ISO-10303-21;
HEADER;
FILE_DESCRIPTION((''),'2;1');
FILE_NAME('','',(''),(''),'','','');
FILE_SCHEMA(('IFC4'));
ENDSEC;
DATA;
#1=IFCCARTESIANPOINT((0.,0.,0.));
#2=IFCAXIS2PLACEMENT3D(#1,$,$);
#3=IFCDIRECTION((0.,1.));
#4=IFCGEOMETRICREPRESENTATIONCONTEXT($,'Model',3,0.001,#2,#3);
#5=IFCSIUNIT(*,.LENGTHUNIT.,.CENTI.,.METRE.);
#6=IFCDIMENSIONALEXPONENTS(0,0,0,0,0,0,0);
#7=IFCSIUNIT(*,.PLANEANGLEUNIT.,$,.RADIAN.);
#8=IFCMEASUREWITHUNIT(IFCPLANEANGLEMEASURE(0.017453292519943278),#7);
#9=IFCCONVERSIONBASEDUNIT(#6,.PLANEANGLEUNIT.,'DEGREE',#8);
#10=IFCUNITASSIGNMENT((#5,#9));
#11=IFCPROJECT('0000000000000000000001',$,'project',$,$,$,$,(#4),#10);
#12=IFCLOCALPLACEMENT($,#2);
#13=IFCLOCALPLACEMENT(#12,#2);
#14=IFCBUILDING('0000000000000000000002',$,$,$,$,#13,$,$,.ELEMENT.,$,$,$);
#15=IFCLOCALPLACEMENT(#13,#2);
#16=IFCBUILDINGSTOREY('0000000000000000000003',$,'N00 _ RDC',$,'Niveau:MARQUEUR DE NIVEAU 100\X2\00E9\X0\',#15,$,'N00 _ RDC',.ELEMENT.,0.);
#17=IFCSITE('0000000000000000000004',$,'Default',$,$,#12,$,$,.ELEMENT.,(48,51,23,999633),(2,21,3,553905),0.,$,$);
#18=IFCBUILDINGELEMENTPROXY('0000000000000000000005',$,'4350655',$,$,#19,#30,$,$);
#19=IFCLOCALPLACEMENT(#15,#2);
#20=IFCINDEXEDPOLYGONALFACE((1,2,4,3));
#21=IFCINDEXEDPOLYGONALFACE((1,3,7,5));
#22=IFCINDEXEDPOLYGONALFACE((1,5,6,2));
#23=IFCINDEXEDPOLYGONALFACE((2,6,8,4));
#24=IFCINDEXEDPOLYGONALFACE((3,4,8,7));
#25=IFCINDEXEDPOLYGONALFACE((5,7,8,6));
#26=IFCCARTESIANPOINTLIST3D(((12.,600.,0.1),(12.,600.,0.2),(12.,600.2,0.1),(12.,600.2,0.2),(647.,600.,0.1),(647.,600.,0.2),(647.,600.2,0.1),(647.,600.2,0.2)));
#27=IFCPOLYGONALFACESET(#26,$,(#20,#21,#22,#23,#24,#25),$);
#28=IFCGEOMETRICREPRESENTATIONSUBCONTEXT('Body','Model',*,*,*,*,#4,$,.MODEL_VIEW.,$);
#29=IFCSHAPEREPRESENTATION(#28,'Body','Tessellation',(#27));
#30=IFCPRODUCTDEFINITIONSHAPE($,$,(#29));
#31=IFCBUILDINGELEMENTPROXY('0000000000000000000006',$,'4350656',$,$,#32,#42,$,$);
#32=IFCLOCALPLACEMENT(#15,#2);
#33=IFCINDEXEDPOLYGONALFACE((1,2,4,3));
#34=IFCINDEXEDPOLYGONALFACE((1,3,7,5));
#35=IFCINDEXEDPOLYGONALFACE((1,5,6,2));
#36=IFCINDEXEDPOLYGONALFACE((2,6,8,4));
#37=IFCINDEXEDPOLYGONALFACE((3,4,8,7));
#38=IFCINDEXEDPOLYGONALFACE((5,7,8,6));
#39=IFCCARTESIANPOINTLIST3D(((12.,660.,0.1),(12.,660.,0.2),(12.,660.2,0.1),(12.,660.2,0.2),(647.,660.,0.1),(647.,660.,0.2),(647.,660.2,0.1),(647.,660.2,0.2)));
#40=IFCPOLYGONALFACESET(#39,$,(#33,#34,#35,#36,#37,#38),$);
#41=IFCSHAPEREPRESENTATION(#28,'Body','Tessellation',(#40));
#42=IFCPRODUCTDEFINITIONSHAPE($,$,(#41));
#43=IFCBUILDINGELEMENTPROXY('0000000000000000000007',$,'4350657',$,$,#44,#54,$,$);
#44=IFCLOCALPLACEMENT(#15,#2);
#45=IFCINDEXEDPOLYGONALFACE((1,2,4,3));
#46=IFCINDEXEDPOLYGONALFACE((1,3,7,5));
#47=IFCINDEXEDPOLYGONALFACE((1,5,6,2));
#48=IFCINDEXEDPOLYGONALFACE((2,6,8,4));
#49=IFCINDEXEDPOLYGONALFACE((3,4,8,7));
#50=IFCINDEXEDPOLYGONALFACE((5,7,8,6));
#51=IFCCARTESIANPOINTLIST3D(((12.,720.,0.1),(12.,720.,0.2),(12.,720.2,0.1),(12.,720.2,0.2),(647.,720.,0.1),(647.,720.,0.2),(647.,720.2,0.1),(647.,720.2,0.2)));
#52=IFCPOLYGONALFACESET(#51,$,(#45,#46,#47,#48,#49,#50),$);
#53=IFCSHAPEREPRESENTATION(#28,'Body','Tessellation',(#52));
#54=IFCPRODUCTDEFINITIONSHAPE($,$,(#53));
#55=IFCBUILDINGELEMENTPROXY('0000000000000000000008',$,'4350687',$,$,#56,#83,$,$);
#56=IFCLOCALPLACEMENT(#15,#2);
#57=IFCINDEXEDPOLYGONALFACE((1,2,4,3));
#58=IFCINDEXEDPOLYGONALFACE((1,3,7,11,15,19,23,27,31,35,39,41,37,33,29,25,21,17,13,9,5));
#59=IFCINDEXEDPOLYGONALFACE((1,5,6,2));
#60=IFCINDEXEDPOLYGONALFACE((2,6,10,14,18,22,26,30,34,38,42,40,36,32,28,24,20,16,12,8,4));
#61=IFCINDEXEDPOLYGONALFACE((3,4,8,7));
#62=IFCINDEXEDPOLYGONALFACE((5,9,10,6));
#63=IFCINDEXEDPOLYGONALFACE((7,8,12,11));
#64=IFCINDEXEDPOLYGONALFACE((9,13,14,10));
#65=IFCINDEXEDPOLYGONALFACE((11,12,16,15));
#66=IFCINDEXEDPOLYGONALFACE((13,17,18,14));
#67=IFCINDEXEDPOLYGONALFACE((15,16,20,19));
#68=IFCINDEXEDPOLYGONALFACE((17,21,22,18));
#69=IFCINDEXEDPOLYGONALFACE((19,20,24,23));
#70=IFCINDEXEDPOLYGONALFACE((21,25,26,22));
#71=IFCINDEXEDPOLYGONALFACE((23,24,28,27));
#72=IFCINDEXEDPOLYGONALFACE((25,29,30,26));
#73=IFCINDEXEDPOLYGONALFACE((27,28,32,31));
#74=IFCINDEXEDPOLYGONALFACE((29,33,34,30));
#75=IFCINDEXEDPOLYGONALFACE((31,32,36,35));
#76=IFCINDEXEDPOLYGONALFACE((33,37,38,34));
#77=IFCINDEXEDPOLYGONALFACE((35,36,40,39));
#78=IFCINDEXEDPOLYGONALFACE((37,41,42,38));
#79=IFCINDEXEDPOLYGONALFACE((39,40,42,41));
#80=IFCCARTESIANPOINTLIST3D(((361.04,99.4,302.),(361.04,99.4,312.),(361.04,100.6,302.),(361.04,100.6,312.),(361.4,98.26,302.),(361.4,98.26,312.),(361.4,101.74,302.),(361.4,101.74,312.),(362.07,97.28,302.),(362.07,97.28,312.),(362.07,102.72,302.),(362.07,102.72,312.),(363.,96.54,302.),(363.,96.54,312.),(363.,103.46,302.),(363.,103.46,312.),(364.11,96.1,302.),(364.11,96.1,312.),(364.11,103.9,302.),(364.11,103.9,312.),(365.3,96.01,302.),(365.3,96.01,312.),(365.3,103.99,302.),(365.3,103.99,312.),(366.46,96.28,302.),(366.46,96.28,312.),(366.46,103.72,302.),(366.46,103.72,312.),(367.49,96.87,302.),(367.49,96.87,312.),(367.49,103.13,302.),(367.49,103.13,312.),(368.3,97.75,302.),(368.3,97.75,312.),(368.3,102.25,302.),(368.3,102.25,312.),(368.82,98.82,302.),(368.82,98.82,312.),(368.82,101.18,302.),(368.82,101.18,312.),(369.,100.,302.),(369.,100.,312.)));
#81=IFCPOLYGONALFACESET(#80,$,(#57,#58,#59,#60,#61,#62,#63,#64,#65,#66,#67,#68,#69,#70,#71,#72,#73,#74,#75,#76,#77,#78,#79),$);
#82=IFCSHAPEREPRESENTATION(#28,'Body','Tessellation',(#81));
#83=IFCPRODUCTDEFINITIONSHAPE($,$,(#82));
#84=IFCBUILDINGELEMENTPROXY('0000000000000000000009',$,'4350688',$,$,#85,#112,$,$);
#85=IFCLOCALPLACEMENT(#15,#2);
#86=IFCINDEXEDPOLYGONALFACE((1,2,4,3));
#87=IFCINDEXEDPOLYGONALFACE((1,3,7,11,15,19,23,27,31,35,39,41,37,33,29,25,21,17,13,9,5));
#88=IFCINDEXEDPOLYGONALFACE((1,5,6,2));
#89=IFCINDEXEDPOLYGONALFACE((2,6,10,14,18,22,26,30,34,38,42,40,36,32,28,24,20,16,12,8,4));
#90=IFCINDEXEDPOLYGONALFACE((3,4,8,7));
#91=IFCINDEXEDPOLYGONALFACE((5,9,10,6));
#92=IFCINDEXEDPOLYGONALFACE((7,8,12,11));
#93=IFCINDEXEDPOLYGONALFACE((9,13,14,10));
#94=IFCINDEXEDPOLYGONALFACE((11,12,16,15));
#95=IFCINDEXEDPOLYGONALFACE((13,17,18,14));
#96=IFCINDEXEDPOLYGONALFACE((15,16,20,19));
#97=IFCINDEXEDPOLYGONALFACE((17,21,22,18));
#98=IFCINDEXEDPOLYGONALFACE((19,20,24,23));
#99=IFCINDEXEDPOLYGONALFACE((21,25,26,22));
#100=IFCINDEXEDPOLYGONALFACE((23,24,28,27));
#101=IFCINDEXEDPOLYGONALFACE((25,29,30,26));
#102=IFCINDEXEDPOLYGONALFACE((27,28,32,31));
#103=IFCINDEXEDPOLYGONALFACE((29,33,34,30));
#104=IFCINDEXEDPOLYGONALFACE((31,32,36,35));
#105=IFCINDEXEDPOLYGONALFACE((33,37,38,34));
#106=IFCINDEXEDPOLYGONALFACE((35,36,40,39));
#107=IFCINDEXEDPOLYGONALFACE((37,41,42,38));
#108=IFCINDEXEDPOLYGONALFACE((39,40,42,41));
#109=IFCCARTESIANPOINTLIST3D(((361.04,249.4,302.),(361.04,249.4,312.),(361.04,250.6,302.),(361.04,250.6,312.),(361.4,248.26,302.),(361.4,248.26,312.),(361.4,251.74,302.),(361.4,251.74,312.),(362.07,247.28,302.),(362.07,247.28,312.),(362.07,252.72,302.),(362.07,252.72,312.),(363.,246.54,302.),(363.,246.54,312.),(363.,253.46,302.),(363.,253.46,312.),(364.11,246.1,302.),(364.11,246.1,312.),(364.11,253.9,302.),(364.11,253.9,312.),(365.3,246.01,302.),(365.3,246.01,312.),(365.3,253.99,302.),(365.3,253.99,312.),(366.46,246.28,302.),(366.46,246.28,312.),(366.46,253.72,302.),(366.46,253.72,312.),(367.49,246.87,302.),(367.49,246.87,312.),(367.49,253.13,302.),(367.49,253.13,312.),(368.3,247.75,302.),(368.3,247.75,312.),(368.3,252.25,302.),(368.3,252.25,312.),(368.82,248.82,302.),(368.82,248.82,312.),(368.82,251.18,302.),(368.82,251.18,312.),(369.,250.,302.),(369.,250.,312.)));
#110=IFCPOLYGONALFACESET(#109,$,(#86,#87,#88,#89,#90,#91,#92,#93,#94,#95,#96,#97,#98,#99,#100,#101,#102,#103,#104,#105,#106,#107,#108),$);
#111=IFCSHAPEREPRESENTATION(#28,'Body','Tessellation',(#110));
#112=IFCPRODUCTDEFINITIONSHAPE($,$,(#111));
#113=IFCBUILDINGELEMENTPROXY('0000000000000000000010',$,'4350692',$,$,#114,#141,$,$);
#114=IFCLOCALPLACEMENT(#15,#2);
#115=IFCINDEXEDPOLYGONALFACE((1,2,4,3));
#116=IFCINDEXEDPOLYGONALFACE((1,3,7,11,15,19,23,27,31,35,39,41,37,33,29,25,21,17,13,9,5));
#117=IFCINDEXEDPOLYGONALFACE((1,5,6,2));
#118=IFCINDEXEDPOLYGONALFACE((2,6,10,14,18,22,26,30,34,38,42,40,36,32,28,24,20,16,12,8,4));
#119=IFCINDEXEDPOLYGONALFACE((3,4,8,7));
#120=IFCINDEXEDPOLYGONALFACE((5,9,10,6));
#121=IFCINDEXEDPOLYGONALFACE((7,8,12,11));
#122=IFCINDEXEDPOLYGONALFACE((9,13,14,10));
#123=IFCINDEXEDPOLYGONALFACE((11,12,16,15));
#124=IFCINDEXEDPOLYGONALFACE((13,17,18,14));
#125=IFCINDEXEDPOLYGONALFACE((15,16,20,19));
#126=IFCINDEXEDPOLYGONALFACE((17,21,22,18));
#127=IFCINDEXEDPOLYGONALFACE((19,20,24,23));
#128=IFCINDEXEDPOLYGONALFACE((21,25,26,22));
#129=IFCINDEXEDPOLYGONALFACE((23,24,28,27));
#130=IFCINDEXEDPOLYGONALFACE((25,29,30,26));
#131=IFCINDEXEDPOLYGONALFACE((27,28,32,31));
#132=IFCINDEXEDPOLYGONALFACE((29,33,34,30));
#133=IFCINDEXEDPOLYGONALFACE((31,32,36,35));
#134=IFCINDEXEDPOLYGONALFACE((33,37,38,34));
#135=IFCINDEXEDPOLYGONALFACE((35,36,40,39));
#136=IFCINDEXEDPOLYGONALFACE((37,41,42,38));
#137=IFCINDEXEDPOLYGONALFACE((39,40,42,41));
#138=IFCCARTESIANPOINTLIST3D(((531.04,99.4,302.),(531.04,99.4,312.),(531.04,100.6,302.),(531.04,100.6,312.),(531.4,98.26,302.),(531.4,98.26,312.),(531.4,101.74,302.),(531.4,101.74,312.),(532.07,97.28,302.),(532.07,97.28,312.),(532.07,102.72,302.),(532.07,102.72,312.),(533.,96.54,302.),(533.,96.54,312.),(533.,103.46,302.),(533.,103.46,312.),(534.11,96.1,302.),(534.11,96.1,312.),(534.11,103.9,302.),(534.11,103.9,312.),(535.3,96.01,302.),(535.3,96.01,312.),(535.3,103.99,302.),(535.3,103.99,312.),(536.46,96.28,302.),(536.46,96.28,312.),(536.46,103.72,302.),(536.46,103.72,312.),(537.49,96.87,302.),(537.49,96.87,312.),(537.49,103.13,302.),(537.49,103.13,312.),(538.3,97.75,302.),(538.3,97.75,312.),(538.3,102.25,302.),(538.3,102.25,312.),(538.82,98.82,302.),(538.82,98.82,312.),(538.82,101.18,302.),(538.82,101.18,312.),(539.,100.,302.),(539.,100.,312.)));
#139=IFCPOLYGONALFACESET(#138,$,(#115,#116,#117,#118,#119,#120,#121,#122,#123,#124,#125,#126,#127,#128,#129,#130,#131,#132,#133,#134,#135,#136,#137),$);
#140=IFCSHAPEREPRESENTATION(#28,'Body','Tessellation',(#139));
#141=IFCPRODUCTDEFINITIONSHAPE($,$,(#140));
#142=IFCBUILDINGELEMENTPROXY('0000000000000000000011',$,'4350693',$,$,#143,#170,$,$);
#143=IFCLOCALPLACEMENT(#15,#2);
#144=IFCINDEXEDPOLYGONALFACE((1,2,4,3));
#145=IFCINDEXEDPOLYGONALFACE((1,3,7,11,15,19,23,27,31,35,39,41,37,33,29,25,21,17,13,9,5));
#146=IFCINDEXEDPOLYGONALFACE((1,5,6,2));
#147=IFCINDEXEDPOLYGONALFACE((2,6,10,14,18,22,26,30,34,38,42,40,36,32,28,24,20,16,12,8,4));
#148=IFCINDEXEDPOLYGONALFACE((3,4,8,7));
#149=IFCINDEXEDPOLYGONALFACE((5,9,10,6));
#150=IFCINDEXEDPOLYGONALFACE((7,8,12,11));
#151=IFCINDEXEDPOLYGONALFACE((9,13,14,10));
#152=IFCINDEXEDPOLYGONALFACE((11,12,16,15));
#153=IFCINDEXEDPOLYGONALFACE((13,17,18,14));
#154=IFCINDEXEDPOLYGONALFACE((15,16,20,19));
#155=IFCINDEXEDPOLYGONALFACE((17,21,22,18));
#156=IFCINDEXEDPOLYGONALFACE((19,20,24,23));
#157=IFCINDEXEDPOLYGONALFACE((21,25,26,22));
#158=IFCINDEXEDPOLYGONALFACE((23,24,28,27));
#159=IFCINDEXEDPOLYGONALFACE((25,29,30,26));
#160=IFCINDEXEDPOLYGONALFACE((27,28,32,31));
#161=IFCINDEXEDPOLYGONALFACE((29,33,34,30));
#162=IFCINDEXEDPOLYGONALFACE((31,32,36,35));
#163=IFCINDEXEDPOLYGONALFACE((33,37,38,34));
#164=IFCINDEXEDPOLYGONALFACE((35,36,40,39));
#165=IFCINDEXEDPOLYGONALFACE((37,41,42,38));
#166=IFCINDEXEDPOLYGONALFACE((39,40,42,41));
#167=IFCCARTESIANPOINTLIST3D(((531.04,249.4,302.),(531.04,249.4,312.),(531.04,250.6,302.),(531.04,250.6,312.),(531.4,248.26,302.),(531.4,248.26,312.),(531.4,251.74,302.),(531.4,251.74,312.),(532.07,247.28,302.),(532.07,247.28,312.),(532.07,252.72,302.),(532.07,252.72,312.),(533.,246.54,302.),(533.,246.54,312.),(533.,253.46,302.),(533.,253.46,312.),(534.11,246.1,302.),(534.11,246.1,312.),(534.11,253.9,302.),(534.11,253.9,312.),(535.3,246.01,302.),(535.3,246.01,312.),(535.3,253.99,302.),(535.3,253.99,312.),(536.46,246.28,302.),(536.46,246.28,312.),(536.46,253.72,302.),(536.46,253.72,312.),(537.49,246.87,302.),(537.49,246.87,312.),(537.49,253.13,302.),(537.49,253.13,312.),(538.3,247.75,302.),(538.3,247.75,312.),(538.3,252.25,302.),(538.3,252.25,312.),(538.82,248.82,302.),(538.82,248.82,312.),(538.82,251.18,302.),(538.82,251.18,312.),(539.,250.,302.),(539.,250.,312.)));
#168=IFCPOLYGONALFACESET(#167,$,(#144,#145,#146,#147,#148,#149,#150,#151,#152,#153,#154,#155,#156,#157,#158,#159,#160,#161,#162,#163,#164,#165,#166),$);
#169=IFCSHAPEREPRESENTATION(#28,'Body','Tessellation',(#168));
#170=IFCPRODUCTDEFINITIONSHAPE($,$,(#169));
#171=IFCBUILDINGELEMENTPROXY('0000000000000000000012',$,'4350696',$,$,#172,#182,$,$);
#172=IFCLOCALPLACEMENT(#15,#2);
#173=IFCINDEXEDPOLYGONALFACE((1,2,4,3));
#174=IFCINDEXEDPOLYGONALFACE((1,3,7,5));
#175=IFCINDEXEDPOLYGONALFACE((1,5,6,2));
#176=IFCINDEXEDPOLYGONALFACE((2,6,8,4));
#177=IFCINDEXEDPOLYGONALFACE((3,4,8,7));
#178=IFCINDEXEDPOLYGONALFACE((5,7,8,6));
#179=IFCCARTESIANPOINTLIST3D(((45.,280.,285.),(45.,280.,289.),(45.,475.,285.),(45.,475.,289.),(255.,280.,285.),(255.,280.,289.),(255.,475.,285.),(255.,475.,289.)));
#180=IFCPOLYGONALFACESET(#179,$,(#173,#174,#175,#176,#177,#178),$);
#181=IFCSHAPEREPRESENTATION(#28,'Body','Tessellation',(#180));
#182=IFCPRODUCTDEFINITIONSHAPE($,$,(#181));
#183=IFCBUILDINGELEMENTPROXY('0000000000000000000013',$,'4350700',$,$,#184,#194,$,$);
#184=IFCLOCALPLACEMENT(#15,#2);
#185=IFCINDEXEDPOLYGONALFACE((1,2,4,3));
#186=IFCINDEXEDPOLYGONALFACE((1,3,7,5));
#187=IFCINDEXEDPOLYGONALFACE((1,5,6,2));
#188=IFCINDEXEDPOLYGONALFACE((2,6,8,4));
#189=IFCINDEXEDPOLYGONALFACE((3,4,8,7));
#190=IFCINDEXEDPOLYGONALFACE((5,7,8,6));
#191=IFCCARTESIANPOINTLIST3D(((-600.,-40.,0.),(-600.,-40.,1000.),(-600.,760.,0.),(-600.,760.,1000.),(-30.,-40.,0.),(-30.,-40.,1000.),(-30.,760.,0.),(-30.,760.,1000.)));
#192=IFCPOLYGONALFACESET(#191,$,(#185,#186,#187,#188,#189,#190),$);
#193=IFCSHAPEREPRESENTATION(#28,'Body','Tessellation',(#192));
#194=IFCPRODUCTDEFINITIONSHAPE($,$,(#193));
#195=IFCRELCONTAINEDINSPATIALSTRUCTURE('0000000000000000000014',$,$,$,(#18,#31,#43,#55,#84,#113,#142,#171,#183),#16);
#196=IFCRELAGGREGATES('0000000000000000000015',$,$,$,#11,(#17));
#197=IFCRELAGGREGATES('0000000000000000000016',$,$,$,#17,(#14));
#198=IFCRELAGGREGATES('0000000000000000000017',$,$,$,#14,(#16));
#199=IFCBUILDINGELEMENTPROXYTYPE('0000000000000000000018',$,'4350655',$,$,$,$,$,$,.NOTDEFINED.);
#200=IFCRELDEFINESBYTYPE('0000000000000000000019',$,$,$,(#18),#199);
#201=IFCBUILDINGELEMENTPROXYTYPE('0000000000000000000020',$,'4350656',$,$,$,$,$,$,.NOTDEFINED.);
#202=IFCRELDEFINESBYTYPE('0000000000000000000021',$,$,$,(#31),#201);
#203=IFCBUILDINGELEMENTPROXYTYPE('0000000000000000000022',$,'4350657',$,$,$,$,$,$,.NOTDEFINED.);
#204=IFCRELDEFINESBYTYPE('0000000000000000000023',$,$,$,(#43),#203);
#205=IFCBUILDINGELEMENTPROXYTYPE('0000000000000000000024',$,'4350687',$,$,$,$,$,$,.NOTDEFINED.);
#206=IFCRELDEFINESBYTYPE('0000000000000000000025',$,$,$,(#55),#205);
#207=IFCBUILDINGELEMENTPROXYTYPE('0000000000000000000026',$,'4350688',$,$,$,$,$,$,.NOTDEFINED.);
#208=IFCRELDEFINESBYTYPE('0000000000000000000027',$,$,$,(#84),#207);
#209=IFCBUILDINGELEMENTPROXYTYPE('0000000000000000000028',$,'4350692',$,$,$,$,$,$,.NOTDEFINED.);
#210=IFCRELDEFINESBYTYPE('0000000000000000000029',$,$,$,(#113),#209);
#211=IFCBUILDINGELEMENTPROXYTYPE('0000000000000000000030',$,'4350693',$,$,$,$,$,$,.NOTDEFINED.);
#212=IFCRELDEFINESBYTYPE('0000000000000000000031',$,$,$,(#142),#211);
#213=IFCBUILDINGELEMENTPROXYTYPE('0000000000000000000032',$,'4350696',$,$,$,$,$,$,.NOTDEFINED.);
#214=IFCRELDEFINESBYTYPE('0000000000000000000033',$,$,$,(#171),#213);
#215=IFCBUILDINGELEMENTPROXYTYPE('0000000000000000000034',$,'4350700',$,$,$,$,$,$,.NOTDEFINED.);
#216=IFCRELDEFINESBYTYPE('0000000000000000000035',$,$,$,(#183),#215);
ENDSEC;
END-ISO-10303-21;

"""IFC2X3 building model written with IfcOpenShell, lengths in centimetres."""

from ifc_helpers import new_model, entity, si_unit, converted_unit, direction, frame, frame_2d, origin, origin_2d_with_axis, place, context, subcontext, project, spatial, rectangle, circle, extrude, type_object, element, save


model = new_model("IFC2X3")

# Units and contexts
model_context = context("Model", 3, precision=0.001, world=origin(), true_north=direction((0.0, 1.0)))
body_context = subcontext(model_context, "Body", "Model", "MODEL_VIEW")
ifc_project = project(units=[si_unit("LENGTHUNIT", "METRE", prefix="CENTI"), converted_unit("PLANEANGLEUNIT", "DEGREE", entity("IfcPlaneAngleMeasure", 0.017453292519943278), si_unit("PLANEANGLEUNIT", "RADIAN"), dimensions=[0, 0, 0, 0, 0, 0, 0])], contexts=[model_context])

# Site, building, storey
site_placement = place(None, origin())
site = spatial("IfcSite", under=ifc_project, at=site_placement, Name="Default", CompositionType="ELEMENT", RefLatitude=(48, 51, 23, 999633), RefLongitude=(2, 21, 3, 553905), RefElevation=0.0)
building_placement = place(site_placement, origin())
building = spatial("IfcBuilding", under=site, at=building_placement, CompositionType="ELEMENT")
storey_placement = place(building_placement, origin())
storey = spatial("IfcBuildingStorey", under=building, at=storey_placement, Name="N00 _ RDC", ObjectType="Niveau:MARQUEUR DE NIVEAU 100é", LongName="N00 _ RDC", CompositionType="ELEMENT", Elevation=0.0)

# Building element proxies
building_element_proxy_type_1 = type_object("IfcBuildingElementProxyType", Name="4350655", PredefinedType="NOTDEFINED")
proxy_1_placement = place(storey_placement, origin())
element("IfcBuildingElementProxy", 1, at=proxy_1_placement, inside=storey, type_object=building_element_proxy_type_1, Name="4350655", context=body_context, shape_type="SweptSolid", body=[
    extrude(rectangle(XDim=635.0, YDim=0.2, at=frame_2d((0.0, 0.0), x_axis=(1.0, 0.0))), frame((329.5, 600.1, 0.1)), (0.0, 0.0, 1.0), 0.1),
])
building_element_proxy_type_2 = type_object("IfcBuildingElementProxyType", Name="4350656", PredefinedType="NOTDEFINED")
proxy_2_placement = place(storey_placement, origin())
element("IfcBuildingElementProxy", 2, at=proxy_2_placement, inside=storey, type_object=building_element_proxy_type_2, Name="4350656", context=body_context, shape_type="SweptSolid", body=[
    extrude(rectangle(XDim=635.0, YDim=0.2, at=frame_2d((0.0, 0.0), x_axis=(1.0, 0.0))), frame((329.5, 660.1, 0.1)), (0.0, 0.0, 1.0), 0.1),
])
building_element_proxy_type_3 = type_object("IfcBuildingElementProxyType", Name="4350657", PredefinedType="NOTDEFINED")
proxy_3_placement = place(storey_placement, origin())
element("IfcBuildingElementProxy", 3, at=proxy_3_placement, inside=storey, type_object=building_element_proxy_type_3, Name="4350657", context=body_context, shape_type="SweptSolid", body=[
    extrude(rectangle(XDim=635.0, YDim=0.2, at=frame_2d((0.0, 0.0), x_axis=(1.0, 0.0))), frame((329.5, 720.1, 0.1)), (0.0, 0.0, 1.0), 0.1),
])
building_element_proxy_type_4 = type_object("IfcBuildingElementProxyType", Name="4350687", PredefinedType="NOTDEFINED")
proxy_4_placement = place(storey_placement, origin())
element("IfcBuildingElementProxy", 4, at=proxy_4_placement, inside=storey, type_object=building_element_proxy_type_4, Name="4350687", context=body_context, shape_type="SweptSolid", body=[
    extrude(circle(Radius=4.0, at=origin_2d_with_axis()), frame((365.0, 100.0, 302.0)), (0.0, 0.0, 1.0), 10.0),
])
building_element_proxy_type_5 = type_object("IfcBuildingElementProxyType", Name="4350688", PredefinedType="NOTDEFINED")
proxy_5_placement = place(storey_placement, origin())
element("IfcBuildingElementProxy", 5, at=proxy_5_placement, inside=storey, type_object=building_element_proxy_type_5, Name="4350688", context=body_context, shape_type="SweptSolid", body=[
    extrude(circle(Radius=4.0, at=origin_2d_with_axis()), frame((365.0, 250.0, 302.0)), (0.0, 0.0, 1.0), 10.0),
])
building_element_proxy_type_6 = type_object("IfcBuildingElementProxyType", Name="4350692", PredefinedType="NOTDEFINED")
proxy_6_placement = place(storey_placement, origin())
element("IfcBuildingElementProxy", 6, at=proxy_6_placement, inside=storey, type_object=building_element_proxy_type_6, Name="4350692", context=body_context, shape_type="SweptSolid", body=[
    extrude(circle(Radius=4.0, at=origin_2d_with_axis()), frame((535.0, 100.0, 302.0)), (0.0, 0.0, 1.0), 10.0),
])
building_element_proxy_type_7 = type_object("IfcBuildingElementProxyType", Name="4350693", PredefinedType="NOTDEFINED")
proxy_7_placement = place(storey_placement, origin())
element("IfcBuildingElementProxy", 7, at=proxy_7_placement, inside=storey, type_object=building_element_proxy_type_7, Name="4350693", context=body_context, shape_type="SweptSolid", body=[
    extrude(circle(Radius=4.0, at=origin_2d_with_axis()), frame((535.0, 250.0, 302.0)), (0.0, 0.0, 1.0), 10.0),
])
building_element_proxy_type_8 = type_object("IfcBuildingElementProxyType", Name="4350696", PredefinedType="NOTDEFINED")
proxy_8_placement = place(storey_placement, origin())
element("IfcBuildingElementProxy", 8, at=proxy_8_placement, inside=storey, type_object=building_element_proxy_type_8, Name="4350696", context=body_context, shape_type="SweptSolid", body=[
    extrude(rectangle(XDim=210.0, YDim=195.0, at=frame_2d((0.0, 0.0), x_axis=(1.0, 0.0))), frame((150.0, 377.5, 285.0)), (0.0, 0.0, 1.0), 4.0),
])
building_element_proxy_type_9 = type_object("IfcBuildingElementProxyType", Name="4350700", PredefinedType="NOTDEFINED")
proxy_9_placement = place(storey_placement, origin())
element("IfcBuildingElementProxy", 9, at=proxy_9_placement, inside=storey, type_object=building_element_proxy_type_9, Name="4350700", context=body_context, shape_type="SweptSolid", body=[
    extrude(rectangle(XDim=570.0, YDim=800.0, at=origin_2d_with_axis()), frame((-315.0, 360.0, 0.0)), (0.0, 0.0, 1.0), 1000.0),
])

save(model, "model.ifc")
